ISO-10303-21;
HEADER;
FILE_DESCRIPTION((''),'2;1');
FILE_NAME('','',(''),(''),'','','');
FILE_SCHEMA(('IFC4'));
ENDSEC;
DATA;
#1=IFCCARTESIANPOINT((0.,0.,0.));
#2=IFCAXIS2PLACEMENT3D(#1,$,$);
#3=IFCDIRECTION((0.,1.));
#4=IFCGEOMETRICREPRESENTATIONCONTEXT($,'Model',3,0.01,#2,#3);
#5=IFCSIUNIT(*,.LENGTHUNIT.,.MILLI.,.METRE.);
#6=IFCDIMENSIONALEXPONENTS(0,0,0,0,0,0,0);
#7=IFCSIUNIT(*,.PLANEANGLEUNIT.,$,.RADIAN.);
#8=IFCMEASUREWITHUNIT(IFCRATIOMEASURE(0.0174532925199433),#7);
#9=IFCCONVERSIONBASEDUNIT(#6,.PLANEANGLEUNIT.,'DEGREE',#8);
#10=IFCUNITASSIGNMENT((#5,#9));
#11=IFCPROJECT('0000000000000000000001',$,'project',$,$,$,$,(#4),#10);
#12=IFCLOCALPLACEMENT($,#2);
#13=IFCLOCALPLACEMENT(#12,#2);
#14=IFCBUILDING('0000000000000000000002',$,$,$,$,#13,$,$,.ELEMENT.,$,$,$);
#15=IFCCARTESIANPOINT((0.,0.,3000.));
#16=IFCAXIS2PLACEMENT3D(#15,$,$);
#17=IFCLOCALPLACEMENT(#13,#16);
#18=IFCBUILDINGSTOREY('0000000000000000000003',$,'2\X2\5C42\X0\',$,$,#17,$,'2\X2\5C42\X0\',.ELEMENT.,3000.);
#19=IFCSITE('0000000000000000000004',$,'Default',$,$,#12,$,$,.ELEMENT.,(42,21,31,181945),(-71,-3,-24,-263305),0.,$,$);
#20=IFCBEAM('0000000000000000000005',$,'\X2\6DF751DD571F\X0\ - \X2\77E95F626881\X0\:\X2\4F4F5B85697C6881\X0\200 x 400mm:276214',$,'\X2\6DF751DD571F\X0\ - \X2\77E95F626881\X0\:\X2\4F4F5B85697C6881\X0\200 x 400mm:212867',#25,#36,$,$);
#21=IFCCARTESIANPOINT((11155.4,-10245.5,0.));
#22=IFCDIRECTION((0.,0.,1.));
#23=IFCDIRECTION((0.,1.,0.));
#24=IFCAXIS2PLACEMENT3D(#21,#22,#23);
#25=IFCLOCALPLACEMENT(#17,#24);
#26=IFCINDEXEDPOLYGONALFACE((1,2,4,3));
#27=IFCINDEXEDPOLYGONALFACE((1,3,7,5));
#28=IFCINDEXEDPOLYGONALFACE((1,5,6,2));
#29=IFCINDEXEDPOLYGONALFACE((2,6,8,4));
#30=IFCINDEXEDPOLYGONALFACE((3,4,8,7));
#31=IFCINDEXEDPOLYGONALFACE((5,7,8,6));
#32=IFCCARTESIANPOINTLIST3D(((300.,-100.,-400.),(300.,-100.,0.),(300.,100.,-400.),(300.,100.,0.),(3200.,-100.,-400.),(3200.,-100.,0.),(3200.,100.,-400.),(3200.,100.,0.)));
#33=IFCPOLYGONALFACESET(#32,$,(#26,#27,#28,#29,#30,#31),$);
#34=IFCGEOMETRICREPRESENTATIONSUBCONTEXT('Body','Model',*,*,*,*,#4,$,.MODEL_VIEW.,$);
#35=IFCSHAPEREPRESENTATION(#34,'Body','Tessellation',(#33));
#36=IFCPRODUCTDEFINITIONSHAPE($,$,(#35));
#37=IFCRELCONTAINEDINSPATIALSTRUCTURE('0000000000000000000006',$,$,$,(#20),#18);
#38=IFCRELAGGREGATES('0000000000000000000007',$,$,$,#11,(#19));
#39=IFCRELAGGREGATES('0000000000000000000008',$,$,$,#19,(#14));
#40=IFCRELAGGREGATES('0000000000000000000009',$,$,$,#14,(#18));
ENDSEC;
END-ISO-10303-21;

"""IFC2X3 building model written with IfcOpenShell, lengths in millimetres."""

from ifc_helpers import new_model, entity, si_unit, converted_unit, direction, frame, frame_2d, origin, place, context, subcontext, project, spatial, rectangle, extrude, element, save


model = new_model("IFC2X3")

# Units and contexts
model_context = context("Model", 3, precision=0.01, world=origin(), true_north=direction((0.0, 1.0)))
body_context = subcontext(model_context, "Body", "Model", "MODEL_VIEW")
ifc_project = project(units=[si_unit("LENGTHUNIT", "METRE", prefix="MILLI"), converted_unit("PLANEANGLEUNIT", "DEGREE", entity("IfcRatioMeasure", 0.0174532925199433), si_unit("PLANEANGLEUNIT", "RADIAN"), dimensions=[0, 0, 0, 0, 0, 0, 0])], contexts=[model_context])

# Site, building, storey
site_placement = place(None, origin())
site = spatial("IfcSite", under=ifc_project, at=site_placement, Name="Default", CompositionType="ELEMENT", RefLatitude=(42, 21, 31, 181945), RefLongitude=(-71, -3, -24, -263305), RefElevation=0.0)
building_placement = place(site_placement, origin())
building = spatial("IfcBuilding", under=site, at=building_placement, CompositionType="ELEMENT")
storey_placement = place(building_placement, frame((0.0, 0.0, 3000.0)))
storey = spatial("IfcBuildingStorey", under=building, at=storey_placement, Name="2层", LongName="2层", CompositionType="ELEMENT", Elevation=3000.0)

# Beam
beam_1_placement = place(storey_placement, frame((11155.4, -10245.5, 0.0), z_axis=(0.0, 0.0, 1.0), x_axis=(0.0, 1.0, 0.0)))
element("IfcBeam", 1, at=beam_1_placement, inside=storey, Name="混凝土 - 矩形梁:住宅楼梁200 x 400mm:276214", ObjectType="混凝土 - 矩形梁:住宅楼梁200 x 400mm:212867", context=body_context, shape_type="SweptSolid", body=[
    extrude(rectangle(XDim=400.0, YDim=200.0, at=frame_2d((0.0, 0.0), x_axis=(1.0, 0.0))), frame((300.0, 0.0, -200.0), z_axis=(1.0, 0.0, 0.0), x_axis=(0.0, 0.0, -1.0)), (0.0, 0.0, 1.0), 2900.0),
])

save(model, "model.ifc")
